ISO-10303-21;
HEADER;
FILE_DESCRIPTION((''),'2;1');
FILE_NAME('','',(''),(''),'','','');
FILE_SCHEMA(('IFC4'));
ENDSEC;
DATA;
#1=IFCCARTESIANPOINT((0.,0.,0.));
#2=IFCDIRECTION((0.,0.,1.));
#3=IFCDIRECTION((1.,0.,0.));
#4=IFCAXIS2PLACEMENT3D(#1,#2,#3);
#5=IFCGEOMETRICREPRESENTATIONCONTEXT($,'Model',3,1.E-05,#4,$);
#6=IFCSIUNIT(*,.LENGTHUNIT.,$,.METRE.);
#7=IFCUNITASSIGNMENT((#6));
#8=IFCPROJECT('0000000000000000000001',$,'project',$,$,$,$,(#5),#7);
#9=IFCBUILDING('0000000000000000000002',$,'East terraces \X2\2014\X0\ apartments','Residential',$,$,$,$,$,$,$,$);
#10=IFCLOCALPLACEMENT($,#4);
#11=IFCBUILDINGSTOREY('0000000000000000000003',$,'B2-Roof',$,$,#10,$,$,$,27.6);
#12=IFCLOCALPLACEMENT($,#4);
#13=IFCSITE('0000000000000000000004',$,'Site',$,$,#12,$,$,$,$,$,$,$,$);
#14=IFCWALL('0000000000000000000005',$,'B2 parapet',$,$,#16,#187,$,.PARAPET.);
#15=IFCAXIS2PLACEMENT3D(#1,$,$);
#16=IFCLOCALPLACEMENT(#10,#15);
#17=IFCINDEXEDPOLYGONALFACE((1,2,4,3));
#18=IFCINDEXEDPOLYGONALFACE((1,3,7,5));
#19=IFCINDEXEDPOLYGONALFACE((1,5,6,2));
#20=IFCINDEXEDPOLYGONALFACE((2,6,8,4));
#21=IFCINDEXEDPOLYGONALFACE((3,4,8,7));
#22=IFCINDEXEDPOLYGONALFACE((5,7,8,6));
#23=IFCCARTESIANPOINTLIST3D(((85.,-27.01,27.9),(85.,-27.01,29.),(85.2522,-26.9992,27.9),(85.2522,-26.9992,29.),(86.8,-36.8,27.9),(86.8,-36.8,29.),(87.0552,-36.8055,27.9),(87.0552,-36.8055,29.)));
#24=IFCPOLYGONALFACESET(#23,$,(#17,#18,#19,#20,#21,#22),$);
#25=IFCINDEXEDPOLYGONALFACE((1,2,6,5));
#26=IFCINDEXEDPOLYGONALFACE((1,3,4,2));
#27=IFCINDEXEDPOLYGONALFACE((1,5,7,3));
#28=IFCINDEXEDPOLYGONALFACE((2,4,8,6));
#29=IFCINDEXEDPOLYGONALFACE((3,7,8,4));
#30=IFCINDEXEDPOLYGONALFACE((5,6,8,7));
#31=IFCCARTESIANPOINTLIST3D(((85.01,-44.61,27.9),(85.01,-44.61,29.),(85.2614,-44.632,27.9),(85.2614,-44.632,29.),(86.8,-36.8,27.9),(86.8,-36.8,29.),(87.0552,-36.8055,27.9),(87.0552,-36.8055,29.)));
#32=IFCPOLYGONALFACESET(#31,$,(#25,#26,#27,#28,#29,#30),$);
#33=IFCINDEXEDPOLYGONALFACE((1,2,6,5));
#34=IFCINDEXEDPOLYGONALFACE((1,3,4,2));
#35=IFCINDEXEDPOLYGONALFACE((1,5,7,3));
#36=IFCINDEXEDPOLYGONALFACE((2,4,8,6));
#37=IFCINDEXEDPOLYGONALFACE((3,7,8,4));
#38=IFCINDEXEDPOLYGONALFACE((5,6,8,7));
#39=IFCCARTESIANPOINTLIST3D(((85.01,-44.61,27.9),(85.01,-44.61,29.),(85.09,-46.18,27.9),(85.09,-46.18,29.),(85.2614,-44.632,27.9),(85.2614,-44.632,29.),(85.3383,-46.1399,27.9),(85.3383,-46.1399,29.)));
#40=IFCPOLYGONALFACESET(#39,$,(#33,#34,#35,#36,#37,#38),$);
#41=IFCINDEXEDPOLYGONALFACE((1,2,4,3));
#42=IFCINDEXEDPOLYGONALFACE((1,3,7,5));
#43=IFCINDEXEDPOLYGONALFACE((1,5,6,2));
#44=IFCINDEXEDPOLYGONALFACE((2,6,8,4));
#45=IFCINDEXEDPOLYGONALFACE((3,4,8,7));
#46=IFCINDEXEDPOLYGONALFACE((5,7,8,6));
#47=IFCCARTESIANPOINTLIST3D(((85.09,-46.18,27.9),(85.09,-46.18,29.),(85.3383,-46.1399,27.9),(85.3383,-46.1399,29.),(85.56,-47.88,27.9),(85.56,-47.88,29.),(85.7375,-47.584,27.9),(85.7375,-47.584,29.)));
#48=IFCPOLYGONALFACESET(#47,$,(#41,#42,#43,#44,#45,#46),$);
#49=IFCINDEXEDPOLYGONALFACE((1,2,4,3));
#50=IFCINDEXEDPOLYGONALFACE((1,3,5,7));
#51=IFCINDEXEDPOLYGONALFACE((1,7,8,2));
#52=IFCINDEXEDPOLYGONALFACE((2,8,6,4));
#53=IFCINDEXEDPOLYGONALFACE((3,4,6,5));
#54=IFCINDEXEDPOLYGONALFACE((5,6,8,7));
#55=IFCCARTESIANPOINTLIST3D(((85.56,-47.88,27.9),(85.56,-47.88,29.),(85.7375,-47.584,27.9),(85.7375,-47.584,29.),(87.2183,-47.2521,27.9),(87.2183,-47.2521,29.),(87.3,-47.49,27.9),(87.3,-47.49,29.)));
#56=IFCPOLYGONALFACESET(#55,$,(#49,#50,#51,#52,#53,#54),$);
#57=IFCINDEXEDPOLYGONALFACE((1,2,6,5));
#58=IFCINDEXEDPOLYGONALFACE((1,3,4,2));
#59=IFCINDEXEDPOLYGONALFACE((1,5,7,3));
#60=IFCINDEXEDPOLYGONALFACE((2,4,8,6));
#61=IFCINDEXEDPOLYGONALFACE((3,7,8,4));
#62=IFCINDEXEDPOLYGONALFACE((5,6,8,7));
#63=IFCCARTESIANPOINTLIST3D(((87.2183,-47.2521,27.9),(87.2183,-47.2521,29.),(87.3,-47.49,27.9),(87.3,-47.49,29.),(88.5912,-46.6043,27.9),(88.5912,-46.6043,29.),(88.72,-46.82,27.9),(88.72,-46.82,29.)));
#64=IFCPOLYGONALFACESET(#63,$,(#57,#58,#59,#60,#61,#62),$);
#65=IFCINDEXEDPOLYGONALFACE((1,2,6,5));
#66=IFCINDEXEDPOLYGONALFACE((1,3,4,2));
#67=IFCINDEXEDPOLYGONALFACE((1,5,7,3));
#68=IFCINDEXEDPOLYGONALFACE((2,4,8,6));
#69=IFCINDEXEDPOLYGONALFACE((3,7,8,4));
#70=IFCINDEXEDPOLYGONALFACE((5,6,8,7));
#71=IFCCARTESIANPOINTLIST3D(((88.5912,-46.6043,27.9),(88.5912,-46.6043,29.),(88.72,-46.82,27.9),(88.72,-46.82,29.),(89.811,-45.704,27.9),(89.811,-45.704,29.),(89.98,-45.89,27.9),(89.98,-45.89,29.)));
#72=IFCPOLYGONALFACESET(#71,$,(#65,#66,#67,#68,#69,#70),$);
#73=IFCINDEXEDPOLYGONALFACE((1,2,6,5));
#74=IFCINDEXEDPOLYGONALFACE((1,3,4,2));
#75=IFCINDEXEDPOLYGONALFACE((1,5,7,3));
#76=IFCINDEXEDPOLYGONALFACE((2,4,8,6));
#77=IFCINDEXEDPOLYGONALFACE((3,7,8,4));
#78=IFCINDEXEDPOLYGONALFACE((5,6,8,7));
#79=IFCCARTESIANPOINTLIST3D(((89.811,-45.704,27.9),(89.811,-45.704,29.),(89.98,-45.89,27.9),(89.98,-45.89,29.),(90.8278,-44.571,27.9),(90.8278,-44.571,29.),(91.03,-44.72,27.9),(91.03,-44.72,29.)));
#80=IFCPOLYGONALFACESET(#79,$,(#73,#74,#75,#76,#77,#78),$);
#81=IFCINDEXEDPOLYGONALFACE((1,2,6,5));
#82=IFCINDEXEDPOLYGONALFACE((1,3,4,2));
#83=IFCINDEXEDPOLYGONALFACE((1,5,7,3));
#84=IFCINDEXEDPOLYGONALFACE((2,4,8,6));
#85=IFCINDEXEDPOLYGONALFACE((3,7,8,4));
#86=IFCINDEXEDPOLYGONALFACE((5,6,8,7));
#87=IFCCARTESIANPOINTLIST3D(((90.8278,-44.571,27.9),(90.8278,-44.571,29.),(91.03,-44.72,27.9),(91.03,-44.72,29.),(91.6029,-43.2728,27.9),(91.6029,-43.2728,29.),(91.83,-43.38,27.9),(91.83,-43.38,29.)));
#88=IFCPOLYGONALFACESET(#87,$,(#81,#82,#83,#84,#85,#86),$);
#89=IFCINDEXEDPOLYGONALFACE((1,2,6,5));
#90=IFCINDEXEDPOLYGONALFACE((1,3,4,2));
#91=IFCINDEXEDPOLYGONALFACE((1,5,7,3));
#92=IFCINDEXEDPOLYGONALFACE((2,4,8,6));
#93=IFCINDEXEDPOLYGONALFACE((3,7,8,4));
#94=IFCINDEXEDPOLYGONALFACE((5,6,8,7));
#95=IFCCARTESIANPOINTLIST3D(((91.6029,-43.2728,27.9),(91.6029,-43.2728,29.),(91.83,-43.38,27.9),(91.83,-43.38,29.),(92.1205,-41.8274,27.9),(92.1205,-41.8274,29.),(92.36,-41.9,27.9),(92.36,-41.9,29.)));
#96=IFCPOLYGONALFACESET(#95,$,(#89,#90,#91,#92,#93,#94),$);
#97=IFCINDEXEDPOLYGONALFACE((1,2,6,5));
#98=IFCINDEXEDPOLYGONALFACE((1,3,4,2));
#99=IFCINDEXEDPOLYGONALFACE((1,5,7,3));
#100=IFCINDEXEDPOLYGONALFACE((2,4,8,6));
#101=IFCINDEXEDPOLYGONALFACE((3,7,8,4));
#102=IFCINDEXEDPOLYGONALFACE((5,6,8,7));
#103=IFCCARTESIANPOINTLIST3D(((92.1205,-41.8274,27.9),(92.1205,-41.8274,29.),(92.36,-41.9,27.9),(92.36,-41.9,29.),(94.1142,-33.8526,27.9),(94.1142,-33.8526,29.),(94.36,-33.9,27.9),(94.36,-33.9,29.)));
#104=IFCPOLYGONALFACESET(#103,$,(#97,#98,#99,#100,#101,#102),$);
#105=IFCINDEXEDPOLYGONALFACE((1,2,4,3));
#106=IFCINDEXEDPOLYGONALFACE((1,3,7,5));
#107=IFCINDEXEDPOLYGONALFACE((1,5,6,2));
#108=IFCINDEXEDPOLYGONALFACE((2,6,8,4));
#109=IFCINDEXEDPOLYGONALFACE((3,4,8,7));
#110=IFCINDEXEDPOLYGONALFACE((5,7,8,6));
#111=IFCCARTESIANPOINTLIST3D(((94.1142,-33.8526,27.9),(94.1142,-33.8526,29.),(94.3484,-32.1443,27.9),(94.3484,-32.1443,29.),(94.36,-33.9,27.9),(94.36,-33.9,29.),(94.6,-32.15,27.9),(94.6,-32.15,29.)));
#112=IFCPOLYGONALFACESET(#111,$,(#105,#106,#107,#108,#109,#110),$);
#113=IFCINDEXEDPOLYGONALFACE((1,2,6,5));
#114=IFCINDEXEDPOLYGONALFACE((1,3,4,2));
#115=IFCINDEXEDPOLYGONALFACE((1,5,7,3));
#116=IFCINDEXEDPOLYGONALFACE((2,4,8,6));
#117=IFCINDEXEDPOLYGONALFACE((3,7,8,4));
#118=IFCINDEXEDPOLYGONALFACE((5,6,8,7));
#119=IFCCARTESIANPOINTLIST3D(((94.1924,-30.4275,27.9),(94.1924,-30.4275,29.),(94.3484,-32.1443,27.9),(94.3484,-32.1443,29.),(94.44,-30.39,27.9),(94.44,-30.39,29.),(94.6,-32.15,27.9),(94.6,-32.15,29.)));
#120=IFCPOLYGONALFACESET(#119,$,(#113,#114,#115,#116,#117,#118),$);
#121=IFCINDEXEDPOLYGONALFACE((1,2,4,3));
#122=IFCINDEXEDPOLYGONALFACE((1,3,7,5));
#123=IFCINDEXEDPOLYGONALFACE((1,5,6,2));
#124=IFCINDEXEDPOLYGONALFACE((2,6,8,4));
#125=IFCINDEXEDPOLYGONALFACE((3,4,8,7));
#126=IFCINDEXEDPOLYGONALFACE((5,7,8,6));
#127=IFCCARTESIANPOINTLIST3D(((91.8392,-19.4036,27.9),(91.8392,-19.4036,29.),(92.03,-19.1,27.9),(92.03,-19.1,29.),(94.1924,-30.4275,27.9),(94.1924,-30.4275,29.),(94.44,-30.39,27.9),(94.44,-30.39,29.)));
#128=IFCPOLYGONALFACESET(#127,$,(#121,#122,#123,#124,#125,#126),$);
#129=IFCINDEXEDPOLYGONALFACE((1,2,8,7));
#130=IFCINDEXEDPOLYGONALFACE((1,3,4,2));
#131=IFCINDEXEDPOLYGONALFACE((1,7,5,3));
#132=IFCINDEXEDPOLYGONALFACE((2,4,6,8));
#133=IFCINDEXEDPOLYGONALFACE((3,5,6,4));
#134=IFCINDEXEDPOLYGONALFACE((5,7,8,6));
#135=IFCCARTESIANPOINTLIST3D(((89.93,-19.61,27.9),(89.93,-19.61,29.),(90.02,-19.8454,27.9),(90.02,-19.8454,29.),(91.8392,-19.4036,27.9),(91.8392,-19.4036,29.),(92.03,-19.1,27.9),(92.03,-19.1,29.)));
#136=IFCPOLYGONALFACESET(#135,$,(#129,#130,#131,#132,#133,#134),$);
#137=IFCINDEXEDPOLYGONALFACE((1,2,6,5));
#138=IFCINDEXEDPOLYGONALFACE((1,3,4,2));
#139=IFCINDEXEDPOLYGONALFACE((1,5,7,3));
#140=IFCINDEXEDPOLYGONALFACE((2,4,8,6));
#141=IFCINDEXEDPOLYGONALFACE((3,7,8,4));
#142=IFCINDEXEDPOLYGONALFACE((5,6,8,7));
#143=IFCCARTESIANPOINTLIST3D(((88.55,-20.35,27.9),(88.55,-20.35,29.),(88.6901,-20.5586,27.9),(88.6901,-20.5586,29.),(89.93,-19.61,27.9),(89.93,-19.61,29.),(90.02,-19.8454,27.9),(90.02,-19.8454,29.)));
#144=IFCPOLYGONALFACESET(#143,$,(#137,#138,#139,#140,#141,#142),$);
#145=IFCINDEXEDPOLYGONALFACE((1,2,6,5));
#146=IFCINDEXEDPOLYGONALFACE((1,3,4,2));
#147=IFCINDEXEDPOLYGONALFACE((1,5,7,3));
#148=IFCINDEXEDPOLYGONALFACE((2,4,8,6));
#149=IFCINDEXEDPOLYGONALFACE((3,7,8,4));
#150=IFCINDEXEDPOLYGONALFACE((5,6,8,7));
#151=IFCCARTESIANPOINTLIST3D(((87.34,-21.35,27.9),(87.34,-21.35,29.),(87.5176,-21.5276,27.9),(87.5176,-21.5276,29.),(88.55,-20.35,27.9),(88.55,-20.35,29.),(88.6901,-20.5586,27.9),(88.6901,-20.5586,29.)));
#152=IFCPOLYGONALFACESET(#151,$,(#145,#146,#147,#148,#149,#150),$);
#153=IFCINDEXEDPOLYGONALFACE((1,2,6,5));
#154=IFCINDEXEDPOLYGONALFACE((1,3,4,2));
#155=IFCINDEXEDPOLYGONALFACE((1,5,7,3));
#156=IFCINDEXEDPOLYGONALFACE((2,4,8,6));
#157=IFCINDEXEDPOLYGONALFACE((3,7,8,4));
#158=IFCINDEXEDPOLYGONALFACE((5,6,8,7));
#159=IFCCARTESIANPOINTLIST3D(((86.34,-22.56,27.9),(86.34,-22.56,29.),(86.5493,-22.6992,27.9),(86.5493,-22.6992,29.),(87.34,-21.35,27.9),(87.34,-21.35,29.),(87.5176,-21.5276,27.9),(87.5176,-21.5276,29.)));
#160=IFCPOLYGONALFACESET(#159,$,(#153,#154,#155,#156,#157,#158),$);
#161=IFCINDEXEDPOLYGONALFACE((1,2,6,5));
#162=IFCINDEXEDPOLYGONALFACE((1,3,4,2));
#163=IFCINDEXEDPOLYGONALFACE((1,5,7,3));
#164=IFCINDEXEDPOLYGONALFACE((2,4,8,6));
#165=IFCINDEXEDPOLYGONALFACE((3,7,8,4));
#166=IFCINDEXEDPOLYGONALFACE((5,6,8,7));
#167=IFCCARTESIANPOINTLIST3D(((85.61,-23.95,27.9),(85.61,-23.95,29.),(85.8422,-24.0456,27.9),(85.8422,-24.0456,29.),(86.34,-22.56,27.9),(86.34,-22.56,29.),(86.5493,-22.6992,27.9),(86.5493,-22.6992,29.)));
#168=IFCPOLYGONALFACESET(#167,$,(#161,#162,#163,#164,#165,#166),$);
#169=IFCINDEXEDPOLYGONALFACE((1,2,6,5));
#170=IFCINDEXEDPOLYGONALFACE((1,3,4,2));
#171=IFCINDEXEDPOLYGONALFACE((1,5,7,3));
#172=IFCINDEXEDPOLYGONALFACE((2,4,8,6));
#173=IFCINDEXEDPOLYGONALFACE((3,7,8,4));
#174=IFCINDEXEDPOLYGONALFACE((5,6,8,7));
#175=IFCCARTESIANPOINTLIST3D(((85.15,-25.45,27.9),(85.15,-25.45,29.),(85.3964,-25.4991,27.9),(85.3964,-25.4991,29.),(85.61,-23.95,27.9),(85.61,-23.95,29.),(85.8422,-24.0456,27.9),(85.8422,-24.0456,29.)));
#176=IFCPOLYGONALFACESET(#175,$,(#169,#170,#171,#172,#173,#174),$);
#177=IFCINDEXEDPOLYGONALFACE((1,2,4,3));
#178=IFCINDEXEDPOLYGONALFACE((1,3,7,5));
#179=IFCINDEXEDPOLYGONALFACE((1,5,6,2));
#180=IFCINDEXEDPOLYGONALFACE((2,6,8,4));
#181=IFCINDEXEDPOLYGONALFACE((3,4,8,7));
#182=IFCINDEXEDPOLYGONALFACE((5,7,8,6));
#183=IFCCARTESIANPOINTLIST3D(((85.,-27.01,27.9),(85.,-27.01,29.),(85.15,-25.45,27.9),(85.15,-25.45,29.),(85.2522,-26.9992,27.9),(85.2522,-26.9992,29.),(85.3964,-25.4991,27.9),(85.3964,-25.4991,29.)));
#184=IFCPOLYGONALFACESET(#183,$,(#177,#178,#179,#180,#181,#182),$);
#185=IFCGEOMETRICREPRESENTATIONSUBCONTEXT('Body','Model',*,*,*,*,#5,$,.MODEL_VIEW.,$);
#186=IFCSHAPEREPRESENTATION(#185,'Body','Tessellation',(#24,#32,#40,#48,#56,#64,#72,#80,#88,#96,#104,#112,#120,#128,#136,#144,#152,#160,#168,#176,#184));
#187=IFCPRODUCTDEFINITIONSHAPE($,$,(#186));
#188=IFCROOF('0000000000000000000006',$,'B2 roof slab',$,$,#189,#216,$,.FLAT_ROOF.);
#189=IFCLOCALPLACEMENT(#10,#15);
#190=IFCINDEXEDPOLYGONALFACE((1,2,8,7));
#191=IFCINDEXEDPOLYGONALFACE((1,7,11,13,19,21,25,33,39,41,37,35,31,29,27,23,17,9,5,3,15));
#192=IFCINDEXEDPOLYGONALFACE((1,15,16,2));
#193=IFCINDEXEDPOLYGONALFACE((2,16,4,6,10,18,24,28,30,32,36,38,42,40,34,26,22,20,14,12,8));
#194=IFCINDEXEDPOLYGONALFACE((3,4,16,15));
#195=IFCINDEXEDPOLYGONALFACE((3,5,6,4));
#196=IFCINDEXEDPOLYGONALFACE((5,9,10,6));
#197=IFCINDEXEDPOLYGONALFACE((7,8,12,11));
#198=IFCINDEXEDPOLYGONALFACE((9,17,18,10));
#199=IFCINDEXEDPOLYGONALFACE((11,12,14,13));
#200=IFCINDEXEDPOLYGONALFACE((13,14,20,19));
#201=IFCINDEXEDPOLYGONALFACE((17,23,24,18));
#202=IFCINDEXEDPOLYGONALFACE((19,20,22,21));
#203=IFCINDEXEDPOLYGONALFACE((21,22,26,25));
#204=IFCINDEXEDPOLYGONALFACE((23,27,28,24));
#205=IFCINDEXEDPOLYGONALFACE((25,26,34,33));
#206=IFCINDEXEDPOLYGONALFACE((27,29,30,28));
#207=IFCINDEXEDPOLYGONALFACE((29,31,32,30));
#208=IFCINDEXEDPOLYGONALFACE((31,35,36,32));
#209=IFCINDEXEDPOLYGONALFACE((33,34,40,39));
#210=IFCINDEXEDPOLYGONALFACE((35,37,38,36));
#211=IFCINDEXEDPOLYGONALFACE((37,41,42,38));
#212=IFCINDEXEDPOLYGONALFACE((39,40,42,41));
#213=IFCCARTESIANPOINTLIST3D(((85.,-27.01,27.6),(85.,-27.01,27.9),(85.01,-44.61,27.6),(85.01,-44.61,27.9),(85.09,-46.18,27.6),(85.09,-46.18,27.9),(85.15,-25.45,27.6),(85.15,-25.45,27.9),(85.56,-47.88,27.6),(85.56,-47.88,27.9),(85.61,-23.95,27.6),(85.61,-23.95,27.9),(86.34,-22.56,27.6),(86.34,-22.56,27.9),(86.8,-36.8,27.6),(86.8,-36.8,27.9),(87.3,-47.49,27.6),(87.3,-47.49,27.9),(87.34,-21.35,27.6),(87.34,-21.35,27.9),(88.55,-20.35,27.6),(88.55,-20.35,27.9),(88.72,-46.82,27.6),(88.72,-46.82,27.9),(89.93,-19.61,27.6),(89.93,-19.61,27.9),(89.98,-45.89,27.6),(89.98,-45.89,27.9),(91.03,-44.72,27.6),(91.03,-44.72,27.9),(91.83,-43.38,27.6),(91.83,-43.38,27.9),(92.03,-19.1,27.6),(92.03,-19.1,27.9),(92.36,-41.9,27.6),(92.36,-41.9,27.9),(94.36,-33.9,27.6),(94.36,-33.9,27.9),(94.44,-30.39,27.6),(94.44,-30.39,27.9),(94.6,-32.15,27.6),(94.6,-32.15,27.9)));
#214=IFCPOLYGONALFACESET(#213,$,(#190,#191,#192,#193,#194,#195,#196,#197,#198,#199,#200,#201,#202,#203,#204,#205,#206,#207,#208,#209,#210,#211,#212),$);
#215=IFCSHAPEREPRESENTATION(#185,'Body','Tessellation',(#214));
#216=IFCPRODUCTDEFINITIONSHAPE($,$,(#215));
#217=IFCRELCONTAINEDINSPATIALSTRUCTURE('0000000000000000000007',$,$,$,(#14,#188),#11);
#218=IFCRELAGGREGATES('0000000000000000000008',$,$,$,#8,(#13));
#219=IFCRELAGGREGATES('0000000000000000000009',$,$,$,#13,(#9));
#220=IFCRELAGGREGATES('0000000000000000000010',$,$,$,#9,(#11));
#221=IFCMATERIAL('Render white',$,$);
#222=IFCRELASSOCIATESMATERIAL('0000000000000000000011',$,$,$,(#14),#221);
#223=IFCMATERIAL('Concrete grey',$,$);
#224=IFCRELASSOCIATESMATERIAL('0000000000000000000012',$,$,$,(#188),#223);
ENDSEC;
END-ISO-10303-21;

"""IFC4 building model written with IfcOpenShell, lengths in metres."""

from ifc_helpers import new_model, si_unit, frame, origin_with_axes, place, context, subcontext, project, spatial, polyline, outline, extrude, material, element, save


model = new_model("IFC4")

# Units and contexts
model_context = context("Model", 3, precision=1e-05, world=origin_with_axes())
body_context = subcontext(model_context, "Body", "Model", "MODEL_VIEW")
ifc_project = project(units=[si_unit("LENGTHUNIT", "METRE")], contexts=[model_context])

# Site, building, storey
site_placement = place(None, origin_with_axes())
site = spatial("IfcSite", under=ifc_project, at=site_placement, Name="Site")
building = spatial("IfcBuilding", under=site, Name="East terraces — apartments", Description="Residential")
storey_placement = place(None, origin_with_axes())
storey = spatial("IfcBuildingStorey", under=building, at=storey_placement, Name="B2-Roof", Elevation=27.6)

# Wall
ifc_material_1 = material(Name="Render white")
wall_placement = place(storey_placement, origin_with_axes())
element("IfcWall", 1, at=wall_placement, inside=storey, material=ifc_material_1, Name="B2 parapet", PredefinedType="PARAPET", context=body_context, shape_type="SweptSolid", body=[
    extrude(outline(polyline([(85.0, -27.01), (86.8, -36.8), (87.0552, -36.8055), (85.2522, -26.9992), (85.0, -27.01)])), frame((0.0, 0.0, 27.9), z_axis=(0.0, 0.0, 1.0), x_axis=(1.0, 0.0, 0.0)), (0.0, 0.0, 1.0), 1.1),
    extrude(outline(polyline([(86.8, -36.8), (85.01, -44.61), (85.2614, -44.632), (87.0552, -36.8055), (86.8, -36.8)])), frame((0.0, 0.0, 27.9), z_axis=(0.0, 0.0, 1.0), x_axis=(1.0, 0.0, 0.0)), (0.0, 0.0, 1.0), 1.1),
    extrude(outline(polyline([(85.01, -44.61), (85.09, -46.18), (85.3383, -46.1399), (85.2614, -44.632), (85.01, -44.61)])), frame((0.0, 0.0, 27.9), z_axis=(0.0, 0.0, 1.0), x_axis=(1.0, 0.0, 0.0)), (0.0, 0.0, 1.0), 1.1),
    extrude(outline(polyline([(85.09, -46.18), (85.56, -47.88), (85.7375, -47.584), (85.3383, -46.1399), (85.09, -46.18)])), frame((0.0, 0.0, 27.9), z_axis=(0.0, 0.0, 1.0), x_axis=(1.0, 0.0, 0.0)), (0.0, 0.0, 1.0), 1.1),
    extrude(outline(polyline([(85.56, -47.88), (87.3, -47.49), (87.2183, -47.2521), (85.7375, -47.584), (85.56, -47.88)])), frame((0.0, 0.0, 27.9), z_axis=(0.0, 0.0, 1.0), x_axis=(1.0, 0.0, 0.0)), (0.0, 0.0, 1.0), 1.1),
    extrude(outline(polyline([(87.3, -47.49), (88.72, -46.82), (88.5912, -46.6043), (87.2183, -47.2521), (87.3, -47.49)])), frame((0.0, 0.0, 27.9), z_axis=(0.0, 0.0, 1.0), x_axis=(1.0, 0.0, 0.0)), (0.0, 0.0, 1.0), 1.1),
    extrude(outline(polyline([(88.72, -46.82), (89.98, -45.89), (89.811, -45.704), (88.5912, -46.6043), (88.72, -46.82)])), frame((0.0, 0.0, 27.9), z_axis=(0.0, 0.0, 1.0), x_axis=(1.0, 0.0, 0.0)), (0.0, 0.0, 1.0), 1.1),
    extrude(outline(polyline([(89.98, -45.89), (91.03, -44.72), (90.8278, -44.571), (89.811, -45.704), (89.98, -45.89)])), frame((0.0, 0.0, 27.9), z_axis=(0.0, 0.0, 1.0), x_axis=(1.0, 0.0, 0.0)), (0.0, 0.0, 1.0), 1.1),
    extrude(outline(polyline([(91.03, -44.72), (91.83, -43.38), (91.6029, -43.2728), (90.8278, -44.571), (91.03, -44.72)])), frame((0.0, 0.0, 27.9), z_axis=(0.0, 0.0, 1.0), x_axis=(1.0, 0.0, 0.0)), (0.0, 0.0, 1.0), 1.1),
    extrude(outline(polyline([(91.83, -43.38), (92.36, -41.9), (92.1205, -41.8274), (91.6029, -43.2728), (91.83, -43.38)])), frame((0.0, 0.0, 27.9), z_axis=(0.0, 0.0, 1.0), x_axis=(1.0, 0.0, 0.0)), (0.0, 0.0, 1.0), 1.1),
    extrude(outline(polyline([(92.36, -41.9), (94.36, -33.9), (94.1142, -33.8526), (92.1205, -41.8274), (92.36, -41.9)])), frame((0.0, 0.0, 27.9), z_axis=(0.0, 0.0, 1.0), x_axis=(1.0, 0.0, 0.0)), (0.0, 0.0, 1.0), 1.1),
    extrude(outline(polyline([(94.36, -33.9), (94.6, -32.15), (94.3484, -32.1443), (94.1142, -33.8526), (94.36, -33.9)])), frame((0.0, 0.0, 27.9), z_axis=(0.0, 0.0, 1.0), x_axis=(1.0, 0.0, 0.0)), (0.0, 0.0, 1.0), 1.1),
    extrude(outline(polyline([(94.6, -32.15), (94.44, -30.39), (94.1924, -30.4275), (94.3484, -32.1443), (94.6, -32.15)])), frame((0.0, 0.0, 27.9), z_axis=(0.0, 0.0, 1.0), x_axis=(1.0, 0.0, 0.0)), (0.0, 0.0, 1.0), 1.1),
    extrude(outline(polyline([(94.44, -30.39), (92.03, -19.1), (91.8392, -19.4036), (94.1924, -30.4275), (94.44, -30.39)])), frame((0.0, 0.0, 27.9), z_axis=(0.0, 0.0, 1.0), x_axis=(1.0, 0.0, 0.0)), (0.0, 0.0, 1.0), 1.1),
    extrude(outline(polyline([(92.03, -19.1), (89.93, -19.61), (90.02, -19.8454), (91.8392, -19.4036), (92.03, -19.1)])), frame((0.0, 0.0, 27.9), z_axis=(0.0, 0.0, 1.0), x_axis=(1.0, 0.0, 0.0)), (0.0, 0.0, 1.0), 1.1),
    extrude(outline(polyline([(89.93, -19.61), (88.55, -20.35), (88.6901, -20.5586), (90.02, -19.8454), (89.93, -19.61)])), frame((0.0, 0.0, 27.9), z_axis=(0.0, 0.0, 1.0), x_axis=(1.0, 0.0, 0.0)), (0.0, 0.0, 1.0), 1.1),
    extrude(outline(polyline([(88.55, -20.35), (87.34, -21.35), (87.5176, -21.5276), (88.6901, -20.5586), (88.55, -20.35)])), frame((0.0, 0.0, 27.9), z_axis=(0.0, 0.0, 1.0), x_axis=(1.0, 0.0, 0.0)), (0.0, 0.0, 1.0), 1.1),
    extrude(outline(polyline([(87.34, -21.35), (86.34, -22.56), (86.5493, -22.6992), (87.5176, -21.5276), (87.34, -21.35)])), frame((0.0, 0.0, 27.9), z_axis=(0.0, 0.0, 1.0), x_axis=(1.0, 0.0, 0.0)), (0.0, 0.0, 1.0), 1.1),
    extrude(outline(polyline([(86.34, -22.56), (85.61, -23.95), (85.8422, -24.0456), (86.5493, -22.6992), (86.34, -22.56)])), frame((0.0, 0.0, 27.9), z_axis=(0.0, 0.0, 1.0), x_axis=(1.0, 0.0, 0.0)), (0.0, 0.0, 1.0), 1.1),
    extrude(outline(polyline([(85.61, -23.95), (85.15, -25.45), (85.3964, -25.4991), (85.8422, -24.0456), (85.61, -23.95)])), frame((0.0, 0.0, 27.9), z_axis=(0.0, 0.0, 1.0), x_axis=(1.0, 0.0, 0.0)), (0.0, 0.0, 1.0), 1.1),
    extrude(outline(polyline([(85.15, -25.45), (85.0, -27.01), (85.2522, -26.9992), (85.3964, -25.4991), (85.15, -25.45)])), frame((0.0, 0.0, 27.9), z_axis=(0.0, 0.0, 1.0), x_axis=(1.0, 0.0, 0.0)), (0.0, 0.0, 1.0), 1.1),
])

# Roof
ifc_material_2 = material(Name="Concrete grey")
roof_placement = place(storey_placement, origin_with_axes())
element("IfcRoof", 2, at=roof_placement, inside=storey, material=ifc_material_2, Name="B2 roof slab", PredefinedType="FLAT_ROOF", context=body_context, shape_type="SweptSolid", body=[
    extrude(outline(polyline([(85.0, -27.01), (86.8, -36.8), (85.01, -44.61), (85.09, -46.18), (85.56, -47.88), (87.3, -47.49), (88.72, -46.82), (89.98, -45.89), (91.03, -44.72), (91.83, -43.38), (92.36, -41.9), (94.36, -33.9), (94.6, -32.15), (94.44, -30.39), (92.03, -19.1), (89.93, -19.61), (88.55, -20.35), (87.34, -21.35), (86.34, -22.56), (85.61, -23.95), (85.15, -25.45), (85.0, -27.01)])), frame((0.0, 0.0, 27.6), z_axis=(0.0, 0.0, 1.0), x_axis=(1.0, 0.0, 0.0)), (0.0, 0.0, 1.0), 0.3),
])

save(model, "model.ifc")
